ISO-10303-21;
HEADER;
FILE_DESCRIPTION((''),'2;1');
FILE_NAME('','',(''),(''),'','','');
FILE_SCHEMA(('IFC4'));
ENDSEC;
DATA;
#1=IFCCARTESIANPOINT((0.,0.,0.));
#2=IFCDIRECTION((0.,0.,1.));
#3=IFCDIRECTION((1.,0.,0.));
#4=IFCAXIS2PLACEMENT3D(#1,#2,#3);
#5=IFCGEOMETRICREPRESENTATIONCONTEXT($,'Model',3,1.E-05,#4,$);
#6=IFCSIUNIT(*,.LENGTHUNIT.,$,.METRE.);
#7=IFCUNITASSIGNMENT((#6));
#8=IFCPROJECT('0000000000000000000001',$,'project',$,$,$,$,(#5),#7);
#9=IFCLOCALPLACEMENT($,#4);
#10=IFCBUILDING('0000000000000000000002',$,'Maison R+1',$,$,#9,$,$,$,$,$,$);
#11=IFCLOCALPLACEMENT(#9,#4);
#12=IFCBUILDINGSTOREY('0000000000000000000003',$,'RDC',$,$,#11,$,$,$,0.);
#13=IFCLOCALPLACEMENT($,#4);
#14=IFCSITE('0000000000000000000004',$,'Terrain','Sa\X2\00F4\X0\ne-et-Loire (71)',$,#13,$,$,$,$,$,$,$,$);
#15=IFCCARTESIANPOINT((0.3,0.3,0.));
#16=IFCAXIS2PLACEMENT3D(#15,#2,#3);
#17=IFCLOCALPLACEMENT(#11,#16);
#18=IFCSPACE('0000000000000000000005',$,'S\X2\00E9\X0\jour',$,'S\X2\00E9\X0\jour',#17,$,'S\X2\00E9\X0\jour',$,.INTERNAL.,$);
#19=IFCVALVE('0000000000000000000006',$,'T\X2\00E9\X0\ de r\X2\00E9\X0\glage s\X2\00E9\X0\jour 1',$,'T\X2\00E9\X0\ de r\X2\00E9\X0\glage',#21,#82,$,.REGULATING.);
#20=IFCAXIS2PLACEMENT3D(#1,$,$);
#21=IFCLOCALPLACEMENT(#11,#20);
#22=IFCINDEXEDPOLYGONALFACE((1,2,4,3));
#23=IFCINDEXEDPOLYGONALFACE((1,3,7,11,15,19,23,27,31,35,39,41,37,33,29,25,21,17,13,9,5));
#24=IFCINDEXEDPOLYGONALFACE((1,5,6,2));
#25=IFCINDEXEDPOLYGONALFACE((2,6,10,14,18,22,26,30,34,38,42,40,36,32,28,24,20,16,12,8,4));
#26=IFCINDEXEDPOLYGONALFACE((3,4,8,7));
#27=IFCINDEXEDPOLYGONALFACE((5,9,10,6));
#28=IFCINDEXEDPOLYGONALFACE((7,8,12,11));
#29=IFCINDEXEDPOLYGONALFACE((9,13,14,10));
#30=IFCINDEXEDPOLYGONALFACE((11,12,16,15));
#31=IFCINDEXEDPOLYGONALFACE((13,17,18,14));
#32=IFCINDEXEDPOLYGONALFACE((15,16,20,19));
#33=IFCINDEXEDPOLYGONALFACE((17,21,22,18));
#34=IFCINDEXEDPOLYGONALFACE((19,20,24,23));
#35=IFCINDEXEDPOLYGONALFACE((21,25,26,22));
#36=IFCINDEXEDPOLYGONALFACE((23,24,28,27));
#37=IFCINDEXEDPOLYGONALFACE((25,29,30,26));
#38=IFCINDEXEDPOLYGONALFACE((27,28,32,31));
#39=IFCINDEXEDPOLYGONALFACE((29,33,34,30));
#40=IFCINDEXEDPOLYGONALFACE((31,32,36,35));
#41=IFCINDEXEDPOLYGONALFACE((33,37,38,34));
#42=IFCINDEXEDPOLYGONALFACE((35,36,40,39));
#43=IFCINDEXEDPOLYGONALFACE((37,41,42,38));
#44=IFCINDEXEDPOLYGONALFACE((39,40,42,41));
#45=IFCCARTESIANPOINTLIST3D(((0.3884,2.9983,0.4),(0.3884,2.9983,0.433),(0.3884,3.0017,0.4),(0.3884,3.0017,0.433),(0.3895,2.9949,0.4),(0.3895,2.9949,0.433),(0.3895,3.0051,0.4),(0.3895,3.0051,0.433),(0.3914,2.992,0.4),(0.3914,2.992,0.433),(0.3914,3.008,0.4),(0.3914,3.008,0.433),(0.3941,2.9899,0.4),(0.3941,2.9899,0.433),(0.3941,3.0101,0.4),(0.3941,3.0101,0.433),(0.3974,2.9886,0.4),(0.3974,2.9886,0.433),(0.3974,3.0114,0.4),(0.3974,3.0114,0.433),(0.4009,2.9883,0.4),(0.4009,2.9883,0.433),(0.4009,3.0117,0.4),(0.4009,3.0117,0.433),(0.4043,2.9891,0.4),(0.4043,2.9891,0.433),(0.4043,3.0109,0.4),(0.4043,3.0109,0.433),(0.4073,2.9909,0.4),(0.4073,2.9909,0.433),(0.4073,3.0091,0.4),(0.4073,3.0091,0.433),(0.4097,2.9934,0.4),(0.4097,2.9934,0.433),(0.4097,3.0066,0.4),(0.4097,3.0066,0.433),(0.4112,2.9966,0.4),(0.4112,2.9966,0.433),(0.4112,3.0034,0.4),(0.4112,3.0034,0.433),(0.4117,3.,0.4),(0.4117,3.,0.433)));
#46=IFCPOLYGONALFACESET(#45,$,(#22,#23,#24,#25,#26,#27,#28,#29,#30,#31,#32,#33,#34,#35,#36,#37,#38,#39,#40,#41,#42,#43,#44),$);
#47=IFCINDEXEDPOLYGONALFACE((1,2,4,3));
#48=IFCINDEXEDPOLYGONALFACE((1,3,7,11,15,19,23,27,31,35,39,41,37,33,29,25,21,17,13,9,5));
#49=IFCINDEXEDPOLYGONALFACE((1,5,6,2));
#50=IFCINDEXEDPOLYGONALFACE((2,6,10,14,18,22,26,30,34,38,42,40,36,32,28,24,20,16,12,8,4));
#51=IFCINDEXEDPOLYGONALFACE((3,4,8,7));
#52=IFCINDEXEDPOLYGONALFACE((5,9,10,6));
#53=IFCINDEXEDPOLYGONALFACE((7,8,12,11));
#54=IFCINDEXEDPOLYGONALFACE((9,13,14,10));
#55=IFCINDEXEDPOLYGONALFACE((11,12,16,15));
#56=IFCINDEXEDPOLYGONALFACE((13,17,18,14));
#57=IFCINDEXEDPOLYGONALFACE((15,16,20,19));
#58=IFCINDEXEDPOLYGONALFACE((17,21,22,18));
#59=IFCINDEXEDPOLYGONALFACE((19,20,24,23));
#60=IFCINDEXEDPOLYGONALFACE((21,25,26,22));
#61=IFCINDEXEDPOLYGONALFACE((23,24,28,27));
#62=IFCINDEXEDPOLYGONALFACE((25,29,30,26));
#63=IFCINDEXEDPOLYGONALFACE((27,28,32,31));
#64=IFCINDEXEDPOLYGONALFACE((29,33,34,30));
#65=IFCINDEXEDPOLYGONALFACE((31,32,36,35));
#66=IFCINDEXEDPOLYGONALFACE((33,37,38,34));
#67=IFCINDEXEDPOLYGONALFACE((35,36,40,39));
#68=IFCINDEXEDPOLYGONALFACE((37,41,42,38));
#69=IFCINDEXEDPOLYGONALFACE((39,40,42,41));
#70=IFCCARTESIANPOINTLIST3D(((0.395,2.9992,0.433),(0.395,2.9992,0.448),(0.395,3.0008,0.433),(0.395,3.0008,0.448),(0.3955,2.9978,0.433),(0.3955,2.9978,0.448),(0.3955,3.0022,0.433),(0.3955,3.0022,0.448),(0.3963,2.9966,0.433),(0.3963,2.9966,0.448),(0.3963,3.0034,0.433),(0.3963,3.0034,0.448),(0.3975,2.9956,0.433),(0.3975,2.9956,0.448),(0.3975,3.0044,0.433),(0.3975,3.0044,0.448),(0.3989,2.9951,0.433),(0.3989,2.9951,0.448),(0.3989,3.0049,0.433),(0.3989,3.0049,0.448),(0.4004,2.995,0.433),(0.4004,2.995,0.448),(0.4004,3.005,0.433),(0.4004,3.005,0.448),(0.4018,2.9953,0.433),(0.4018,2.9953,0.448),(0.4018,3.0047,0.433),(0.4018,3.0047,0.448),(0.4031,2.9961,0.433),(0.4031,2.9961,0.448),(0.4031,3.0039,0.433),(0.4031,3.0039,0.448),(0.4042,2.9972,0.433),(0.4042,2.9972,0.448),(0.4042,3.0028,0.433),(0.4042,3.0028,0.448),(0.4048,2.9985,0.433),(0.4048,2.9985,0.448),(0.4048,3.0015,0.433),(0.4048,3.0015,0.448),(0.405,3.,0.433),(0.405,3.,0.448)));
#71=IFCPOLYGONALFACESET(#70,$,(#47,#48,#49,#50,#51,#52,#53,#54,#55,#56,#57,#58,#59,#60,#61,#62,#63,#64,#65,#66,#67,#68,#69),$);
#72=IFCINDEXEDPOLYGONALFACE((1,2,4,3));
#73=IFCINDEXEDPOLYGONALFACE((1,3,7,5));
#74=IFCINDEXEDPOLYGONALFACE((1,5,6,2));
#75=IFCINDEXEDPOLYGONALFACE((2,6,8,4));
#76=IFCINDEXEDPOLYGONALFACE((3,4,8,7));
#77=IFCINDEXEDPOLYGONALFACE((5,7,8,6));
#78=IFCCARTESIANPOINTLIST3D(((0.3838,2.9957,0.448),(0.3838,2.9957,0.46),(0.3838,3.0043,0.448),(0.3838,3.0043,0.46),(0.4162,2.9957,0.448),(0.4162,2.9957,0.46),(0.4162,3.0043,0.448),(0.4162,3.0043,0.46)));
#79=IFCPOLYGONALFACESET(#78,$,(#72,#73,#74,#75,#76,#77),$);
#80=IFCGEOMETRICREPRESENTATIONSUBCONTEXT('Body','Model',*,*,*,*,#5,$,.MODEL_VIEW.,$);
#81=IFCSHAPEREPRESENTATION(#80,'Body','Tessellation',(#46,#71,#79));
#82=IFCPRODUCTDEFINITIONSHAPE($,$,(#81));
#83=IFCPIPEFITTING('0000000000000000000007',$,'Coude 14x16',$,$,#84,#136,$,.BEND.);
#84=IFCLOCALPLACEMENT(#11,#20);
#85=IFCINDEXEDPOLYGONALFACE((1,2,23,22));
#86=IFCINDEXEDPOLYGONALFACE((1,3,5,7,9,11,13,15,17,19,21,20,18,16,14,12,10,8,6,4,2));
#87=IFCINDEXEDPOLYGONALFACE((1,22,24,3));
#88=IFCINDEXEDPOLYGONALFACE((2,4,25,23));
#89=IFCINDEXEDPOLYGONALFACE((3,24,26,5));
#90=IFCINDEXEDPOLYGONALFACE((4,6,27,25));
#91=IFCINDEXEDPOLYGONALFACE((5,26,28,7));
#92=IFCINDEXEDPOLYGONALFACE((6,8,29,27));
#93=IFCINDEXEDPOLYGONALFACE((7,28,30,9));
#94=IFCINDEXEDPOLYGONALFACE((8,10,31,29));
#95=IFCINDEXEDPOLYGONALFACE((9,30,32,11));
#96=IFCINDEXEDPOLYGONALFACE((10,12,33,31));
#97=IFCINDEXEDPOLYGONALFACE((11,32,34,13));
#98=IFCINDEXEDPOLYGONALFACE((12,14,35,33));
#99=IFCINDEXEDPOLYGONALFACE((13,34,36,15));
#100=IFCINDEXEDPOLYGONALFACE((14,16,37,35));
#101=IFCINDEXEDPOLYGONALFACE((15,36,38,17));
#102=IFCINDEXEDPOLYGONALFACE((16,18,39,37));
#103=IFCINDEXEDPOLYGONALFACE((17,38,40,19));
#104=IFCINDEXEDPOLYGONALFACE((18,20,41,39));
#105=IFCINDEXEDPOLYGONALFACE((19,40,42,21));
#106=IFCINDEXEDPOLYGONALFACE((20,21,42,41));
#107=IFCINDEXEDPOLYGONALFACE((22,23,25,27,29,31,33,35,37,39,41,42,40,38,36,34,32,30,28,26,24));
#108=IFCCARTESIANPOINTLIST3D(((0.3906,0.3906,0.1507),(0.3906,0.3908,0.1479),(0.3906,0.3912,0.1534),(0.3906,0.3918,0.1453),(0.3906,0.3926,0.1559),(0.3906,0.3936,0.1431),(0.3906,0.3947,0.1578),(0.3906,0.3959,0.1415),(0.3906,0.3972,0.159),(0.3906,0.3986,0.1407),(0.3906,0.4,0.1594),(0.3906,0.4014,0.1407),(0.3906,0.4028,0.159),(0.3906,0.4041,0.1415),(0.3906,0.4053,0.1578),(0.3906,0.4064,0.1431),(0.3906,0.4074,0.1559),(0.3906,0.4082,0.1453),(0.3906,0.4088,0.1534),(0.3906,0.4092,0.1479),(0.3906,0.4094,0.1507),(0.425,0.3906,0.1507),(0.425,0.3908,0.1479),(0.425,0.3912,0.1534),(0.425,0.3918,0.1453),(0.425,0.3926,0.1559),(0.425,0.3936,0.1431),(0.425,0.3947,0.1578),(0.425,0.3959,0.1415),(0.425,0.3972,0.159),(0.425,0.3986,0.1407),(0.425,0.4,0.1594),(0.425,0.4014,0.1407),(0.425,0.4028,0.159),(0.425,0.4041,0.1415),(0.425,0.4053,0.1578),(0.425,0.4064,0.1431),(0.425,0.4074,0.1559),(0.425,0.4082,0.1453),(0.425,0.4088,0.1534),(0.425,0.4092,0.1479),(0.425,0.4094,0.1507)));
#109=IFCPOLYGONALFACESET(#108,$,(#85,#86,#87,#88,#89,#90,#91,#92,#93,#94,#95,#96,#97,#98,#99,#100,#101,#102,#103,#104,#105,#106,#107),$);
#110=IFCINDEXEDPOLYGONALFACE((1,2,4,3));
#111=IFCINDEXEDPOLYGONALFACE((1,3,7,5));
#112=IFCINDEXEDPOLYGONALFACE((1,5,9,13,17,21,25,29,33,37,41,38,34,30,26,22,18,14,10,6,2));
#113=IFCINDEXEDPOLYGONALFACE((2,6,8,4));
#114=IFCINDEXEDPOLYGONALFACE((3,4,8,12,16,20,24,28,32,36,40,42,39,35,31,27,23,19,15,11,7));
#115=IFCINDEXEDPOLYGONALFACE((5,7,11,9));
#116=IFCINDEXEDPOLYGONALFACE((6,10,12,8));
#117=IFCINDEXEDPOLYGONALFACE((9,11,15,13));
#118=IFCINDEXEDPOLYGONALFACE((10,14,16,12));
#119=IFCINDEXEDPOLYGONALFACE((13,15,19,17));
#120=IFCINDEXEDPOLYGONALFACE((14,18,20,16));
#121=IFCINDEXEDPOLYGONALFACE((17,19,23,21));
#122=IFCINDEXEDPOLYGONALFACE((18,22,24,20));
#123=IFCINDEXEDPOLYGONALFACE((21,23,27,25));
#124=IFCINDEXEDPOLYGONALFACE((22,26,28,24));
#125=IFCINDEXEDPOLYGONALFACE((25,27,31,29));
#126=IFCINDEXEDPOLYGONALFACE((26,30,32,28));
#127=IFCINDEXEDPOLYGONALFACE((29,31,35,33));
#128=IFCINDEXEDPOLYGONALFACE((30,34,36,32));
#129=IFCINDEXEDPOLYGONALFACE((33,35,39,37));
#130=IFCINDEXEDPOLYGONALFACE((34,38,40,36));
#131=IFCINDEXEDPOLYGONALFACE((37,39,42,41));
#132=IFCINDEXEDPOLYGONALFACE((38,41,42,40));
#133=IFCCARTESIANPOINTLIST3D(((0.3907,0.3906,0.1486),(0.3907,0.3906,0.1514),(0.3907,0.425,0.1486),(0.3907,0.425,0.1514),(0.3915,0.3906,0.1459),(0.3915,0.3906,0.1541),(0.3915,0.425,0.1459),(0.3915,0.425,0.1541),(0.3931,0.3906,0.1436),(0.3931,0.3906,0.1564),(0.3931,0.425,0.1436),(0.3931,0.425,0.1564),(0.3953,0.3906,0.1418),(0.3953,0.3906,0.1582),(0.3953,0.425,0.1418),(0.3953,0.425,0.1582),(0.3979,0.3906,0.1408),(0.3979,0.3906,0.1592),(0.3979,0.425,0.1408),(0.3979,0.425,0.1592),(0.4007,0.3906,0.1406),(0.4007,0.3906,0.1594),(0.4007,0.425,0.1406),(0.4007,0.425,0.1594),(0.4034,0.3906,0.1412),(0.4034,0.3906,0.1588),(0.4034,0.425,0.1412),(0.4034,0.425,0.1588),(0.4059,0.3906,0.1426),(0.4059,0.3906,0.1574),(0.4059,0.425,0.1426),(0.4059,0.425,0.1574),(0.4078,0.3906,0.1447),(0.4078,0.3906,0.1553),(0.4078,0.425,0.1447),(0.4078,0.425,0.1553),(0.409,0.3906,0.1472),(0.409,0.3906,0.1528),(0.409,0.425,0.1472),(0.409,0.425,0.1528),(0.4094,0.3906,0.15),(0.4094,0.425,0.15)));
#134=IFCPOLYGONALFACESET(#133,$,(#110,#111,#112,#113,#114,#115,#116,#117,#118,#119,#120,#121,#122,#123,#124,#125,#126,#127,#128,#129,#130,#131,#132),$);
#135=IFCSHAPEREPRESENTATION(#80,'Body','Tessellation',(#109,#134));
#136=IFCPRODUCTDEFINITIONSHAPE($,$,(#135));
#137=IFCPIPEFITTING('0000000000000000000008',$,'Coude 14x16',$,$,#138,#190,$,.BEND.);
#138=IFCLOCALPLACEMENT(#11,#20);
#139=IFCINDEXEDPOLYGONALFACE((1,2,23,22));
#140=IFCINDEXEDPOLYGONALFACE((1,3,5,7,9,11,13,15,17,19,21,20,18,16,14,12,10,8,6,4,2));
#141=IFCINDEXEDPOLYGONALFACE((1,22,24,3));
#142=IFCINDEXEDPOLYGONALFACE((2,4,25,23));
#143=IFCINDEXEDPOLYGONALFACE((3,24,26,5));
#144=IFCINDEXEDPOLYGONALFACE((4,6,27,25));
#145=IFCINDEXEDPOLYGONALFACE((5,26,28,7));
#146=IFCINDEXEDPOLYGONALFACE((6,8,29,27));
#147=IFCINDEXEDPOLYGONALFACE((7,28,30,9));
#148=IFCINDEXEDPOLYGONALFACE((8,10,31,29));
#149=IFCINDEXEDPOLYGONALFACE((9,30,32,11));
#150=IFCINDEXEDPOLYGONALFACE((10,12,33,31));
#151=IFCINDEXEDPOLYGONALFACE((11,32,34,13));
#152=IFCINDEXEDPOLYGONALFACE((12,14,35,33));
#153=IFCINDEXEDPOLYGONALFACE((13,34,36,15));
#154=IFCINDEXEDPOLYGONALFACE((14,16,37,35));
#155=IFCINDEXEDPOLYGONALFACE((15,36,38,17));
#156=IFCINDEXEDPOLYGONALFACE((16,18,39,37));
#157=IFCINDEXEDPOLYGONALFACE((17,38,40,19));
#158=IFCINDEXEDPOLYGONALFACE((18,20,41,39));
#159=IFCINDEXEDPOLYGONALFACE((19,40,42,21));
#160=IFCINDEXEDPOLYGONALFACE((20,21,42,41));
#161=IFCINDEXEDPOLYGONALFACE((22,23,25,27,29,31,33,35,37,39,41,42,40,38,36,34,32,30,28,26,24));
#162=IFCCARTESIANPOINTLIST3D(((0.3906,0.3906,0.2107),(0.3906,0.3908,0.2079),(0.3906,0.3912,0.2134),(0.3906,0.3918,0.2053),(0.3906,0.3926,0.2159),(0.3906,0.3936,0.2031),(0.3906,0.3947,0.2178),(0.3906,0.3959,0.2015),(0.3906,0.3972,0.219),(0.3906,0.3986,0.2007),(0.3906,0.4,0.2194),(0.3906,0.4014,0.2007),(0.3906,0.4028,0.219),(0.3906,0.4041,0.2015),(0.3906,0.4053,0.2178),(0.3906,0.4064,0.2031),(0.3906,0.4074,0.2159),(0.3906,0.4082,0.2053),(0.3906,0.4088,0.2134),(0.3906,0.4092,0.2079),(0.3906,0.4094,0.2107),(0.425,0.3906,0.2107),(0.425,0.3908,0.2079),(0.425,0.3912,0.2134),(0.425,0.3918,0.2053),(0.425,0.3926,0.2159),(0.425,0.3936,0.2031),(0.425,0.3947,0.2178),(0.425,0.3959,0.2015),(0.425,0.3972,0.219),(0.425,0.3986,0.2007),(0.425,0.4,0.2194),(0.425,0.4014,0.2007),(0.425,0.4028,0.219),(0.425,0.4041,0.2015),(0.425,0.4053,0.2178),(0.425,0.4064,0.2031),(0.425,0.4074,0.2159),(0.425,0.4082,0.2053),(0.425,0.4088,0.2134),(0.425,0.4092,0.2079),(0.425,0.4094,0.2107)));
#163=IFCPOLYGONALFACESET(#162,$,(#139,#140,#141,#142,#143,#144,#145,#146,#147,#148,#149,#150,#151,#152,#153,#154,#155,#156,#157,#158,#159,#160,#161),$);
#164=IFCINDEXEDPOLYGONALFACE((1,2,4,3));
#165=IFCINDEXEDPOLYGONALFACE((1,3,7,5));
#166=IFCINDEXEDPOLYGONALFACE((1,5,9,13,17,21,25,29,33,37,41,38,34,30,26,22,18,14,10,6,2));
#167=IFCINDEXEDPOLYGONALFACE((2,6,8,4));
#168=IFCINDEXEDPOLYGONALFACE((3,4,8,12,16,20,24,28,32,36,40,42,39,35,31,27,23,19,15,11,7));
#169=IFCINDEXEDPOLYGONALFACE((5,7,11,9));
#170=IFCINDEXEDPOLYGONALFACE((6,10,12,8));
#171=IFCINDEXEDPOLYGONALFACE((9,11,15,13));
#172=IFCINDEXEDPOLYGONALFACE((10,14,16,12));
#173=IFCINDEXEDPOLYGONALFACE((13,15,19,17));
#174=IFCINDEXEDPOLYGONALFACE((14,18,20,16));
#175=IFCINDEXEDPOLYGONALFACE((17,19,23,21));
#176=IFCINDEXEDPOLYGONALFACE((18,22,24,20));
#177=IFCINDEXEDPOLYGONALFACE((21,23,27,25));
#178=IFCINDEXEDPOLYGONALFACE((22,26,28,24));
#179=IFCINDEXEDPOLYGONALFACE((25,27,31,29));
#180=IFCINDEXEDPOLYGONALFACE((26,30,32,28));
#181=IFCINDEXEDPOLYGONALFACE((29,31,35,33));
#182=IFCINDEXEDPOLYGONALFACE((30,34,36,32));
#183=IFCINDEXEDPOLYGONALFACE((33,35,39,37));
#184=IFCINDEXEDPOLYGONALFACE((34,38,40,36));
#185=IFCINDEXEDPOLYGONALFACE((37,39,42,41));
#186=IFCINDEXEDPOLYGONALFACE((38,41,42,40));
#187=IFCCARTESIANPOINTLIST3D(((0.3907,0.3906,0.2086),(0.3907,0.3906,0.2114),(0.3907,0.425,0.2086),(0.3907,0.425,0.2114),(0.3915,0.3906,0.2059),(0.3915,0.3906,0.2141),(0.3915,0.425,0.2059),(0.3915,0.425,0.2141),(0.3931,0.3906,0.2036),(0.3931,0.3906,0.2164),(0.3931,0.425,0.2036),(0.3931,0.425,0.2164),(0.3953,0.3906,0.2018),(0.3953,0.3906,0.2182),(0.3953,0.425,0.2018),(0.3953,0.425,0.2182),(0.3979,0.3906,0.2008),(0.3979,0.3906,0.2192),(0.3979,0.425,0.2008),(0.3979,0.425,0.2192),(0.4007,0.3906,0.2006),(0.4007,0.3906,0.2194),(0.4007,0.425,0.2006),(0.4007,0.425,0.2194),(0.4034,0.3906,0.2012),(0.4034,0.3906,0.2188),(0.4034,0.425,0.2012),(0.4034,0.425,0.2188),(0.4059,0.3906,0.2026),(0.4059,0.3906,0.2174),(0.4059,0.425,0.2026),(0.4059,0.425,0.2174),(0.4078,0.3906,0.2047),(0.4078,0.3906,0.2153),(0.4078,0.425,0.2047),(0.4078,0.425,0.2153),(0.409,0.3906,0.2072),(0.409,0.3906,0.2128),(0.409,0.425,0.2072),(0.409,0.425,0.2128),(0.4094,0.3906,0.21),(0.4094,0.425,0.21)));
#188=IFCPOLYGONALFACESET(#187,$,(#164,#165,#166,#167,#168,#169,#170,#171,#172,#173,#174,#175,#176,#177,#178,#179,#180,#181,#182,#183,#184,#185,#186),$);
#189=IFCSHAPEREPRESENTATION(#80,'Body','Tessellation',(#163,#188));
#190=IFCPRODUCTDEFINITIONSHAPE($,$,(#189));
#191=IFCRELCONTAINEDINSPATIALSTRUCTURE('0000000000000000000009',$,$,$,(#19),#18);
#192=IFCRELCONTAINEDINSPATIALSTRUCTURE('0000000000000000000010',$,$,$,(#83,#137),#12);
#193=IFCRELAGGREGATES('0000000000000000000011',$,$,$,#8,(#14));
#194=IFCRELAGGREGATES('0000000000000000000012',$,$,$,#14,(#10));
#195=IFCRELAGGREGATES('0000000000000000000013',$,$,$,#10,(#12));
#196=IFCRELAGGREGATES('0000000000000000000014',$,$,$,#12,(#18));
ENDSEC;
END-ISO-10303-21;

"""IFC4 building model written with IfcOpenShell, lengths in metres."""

from ifc_helpers import new_model, si_unit, frame, frame_2d, origin_with_axes, place, context, subcontext, project, spatial, rectangle, circle, extrude, element, save


model = new_model("IFC4")

# Units and contexts
model_context = context("Model", 3, precision=1e-05, world=origin_with_axes())
body_context = subcontext(model_context, "Body", "Model", "MODEL_VIEW")
ifc_project = project(units=[si_unit("LENGTHUNIT", "METRE")], contexts=[model_context])

# Site, building, storey
site_placement = place(None, origin_with_axes())
site = spatial("IfcSite", under=ifc_project, at=site_placement, Name="Terrain", Description="Saône-et-Loire (71)")
building_placement = place(None, origin_with_axes())
building = spatial("IfcBuilding", under=site, at=building_placement, Name="Maison R+1")
storey_placement = place(building_placement, origin_with_axes())
storey = spatial("IfcBuildingStorey", under=building, at=storey_placement, Name="RDC", Elevation=0.0)

# Shared definitions
space_placement = place(storey_placement, frame((0.3, 0.3, 0.0), z_axis=(0.0, 0.0, 1.0), x_axis=(1.0, 0.0, 0.0)))
space = spatial("IfcSpace", under=storey, at=space_placement, Name="Séjour", ObjectType="Séjour", LongName="Séjour", PredefinedType="INTERNAL")

# Valve
valve_1_placement = place(space_placement, frame((0.1, 2.7, 0.4), z_axis=(0.0, 0.0, 1.0), x_axis=(1.0, 0.0, 0.0)))
element("IfcValve", 1, at=valve_1_placement, inside=space, Name="Té de réglage séjour 1", ObjectType="Té de réglage", PredefinedType="REGULATING", context=body_context, shape_type="SweptSolid", body=[
    extrude(circle(Radius=0.0117), origin_with_axes(), (0.0, 0.0, 1.0), 0.033),
    extrude(circle(Radius=0.005), frame((0.0, 0.0, 0.033), z_axis=(0.0, 0.0, 1.0), x_axis=(1.0, 0.0, 0.0)), (0.0, 0.0, 1.0), 0.015),
    extrude(rectangle(XDim=0.0324, YDim=0.0086, at=frame_2d((0.0162, 0.0043))), frame((-0.0162, -0.0043, 0.048), z_axis=(0.0, 0.0, 1.0), x_axis=(1.0, 0.0, 0.0)), (0.0, 0.0, 1.0), 0.012),
])

# Pipe fittings
for number, where, z_axis, x_axis, name in (
    (2, (0.4, 0.4, 0.15), (0.0, 0.0, 1.0), (1.0, 0.0, 0.0), "Coude 14x16"),
    (3, (0.4, 0.4, 0.21), (0.0, 0.0, 1.0), (1.0, 0.0, 0.0), "Coude 14x16"),
):
    element("IfcPipeFitting", number, at=place(storey_placement, frame(where, z_axis=z_axis, x_axis=x_axis)), inside=storey, Name=name, PredefinedType="BEND", context=body_context, shape_type="SweptSolid", body=[
        extrude(circle(Radius=0.0094), frame((-0.0094, 0.0, 0.0), z_axis=(1.0, 0.0, 0.0), x_axis=(0.0, 0.0, 1.0)), (0.0, 0.0, 1.0), 0.0344),
        extrude(circle(Radius=0.0094), frame((0.0, -0.0094, 0.0), z_axis=(0.0, 1.0, 0.0), x_axis=(1.0, 0.0, 0.0)), (0.0, 0.0, 1.0), 0.0344),
    ])

save(model, "model.ifc")
